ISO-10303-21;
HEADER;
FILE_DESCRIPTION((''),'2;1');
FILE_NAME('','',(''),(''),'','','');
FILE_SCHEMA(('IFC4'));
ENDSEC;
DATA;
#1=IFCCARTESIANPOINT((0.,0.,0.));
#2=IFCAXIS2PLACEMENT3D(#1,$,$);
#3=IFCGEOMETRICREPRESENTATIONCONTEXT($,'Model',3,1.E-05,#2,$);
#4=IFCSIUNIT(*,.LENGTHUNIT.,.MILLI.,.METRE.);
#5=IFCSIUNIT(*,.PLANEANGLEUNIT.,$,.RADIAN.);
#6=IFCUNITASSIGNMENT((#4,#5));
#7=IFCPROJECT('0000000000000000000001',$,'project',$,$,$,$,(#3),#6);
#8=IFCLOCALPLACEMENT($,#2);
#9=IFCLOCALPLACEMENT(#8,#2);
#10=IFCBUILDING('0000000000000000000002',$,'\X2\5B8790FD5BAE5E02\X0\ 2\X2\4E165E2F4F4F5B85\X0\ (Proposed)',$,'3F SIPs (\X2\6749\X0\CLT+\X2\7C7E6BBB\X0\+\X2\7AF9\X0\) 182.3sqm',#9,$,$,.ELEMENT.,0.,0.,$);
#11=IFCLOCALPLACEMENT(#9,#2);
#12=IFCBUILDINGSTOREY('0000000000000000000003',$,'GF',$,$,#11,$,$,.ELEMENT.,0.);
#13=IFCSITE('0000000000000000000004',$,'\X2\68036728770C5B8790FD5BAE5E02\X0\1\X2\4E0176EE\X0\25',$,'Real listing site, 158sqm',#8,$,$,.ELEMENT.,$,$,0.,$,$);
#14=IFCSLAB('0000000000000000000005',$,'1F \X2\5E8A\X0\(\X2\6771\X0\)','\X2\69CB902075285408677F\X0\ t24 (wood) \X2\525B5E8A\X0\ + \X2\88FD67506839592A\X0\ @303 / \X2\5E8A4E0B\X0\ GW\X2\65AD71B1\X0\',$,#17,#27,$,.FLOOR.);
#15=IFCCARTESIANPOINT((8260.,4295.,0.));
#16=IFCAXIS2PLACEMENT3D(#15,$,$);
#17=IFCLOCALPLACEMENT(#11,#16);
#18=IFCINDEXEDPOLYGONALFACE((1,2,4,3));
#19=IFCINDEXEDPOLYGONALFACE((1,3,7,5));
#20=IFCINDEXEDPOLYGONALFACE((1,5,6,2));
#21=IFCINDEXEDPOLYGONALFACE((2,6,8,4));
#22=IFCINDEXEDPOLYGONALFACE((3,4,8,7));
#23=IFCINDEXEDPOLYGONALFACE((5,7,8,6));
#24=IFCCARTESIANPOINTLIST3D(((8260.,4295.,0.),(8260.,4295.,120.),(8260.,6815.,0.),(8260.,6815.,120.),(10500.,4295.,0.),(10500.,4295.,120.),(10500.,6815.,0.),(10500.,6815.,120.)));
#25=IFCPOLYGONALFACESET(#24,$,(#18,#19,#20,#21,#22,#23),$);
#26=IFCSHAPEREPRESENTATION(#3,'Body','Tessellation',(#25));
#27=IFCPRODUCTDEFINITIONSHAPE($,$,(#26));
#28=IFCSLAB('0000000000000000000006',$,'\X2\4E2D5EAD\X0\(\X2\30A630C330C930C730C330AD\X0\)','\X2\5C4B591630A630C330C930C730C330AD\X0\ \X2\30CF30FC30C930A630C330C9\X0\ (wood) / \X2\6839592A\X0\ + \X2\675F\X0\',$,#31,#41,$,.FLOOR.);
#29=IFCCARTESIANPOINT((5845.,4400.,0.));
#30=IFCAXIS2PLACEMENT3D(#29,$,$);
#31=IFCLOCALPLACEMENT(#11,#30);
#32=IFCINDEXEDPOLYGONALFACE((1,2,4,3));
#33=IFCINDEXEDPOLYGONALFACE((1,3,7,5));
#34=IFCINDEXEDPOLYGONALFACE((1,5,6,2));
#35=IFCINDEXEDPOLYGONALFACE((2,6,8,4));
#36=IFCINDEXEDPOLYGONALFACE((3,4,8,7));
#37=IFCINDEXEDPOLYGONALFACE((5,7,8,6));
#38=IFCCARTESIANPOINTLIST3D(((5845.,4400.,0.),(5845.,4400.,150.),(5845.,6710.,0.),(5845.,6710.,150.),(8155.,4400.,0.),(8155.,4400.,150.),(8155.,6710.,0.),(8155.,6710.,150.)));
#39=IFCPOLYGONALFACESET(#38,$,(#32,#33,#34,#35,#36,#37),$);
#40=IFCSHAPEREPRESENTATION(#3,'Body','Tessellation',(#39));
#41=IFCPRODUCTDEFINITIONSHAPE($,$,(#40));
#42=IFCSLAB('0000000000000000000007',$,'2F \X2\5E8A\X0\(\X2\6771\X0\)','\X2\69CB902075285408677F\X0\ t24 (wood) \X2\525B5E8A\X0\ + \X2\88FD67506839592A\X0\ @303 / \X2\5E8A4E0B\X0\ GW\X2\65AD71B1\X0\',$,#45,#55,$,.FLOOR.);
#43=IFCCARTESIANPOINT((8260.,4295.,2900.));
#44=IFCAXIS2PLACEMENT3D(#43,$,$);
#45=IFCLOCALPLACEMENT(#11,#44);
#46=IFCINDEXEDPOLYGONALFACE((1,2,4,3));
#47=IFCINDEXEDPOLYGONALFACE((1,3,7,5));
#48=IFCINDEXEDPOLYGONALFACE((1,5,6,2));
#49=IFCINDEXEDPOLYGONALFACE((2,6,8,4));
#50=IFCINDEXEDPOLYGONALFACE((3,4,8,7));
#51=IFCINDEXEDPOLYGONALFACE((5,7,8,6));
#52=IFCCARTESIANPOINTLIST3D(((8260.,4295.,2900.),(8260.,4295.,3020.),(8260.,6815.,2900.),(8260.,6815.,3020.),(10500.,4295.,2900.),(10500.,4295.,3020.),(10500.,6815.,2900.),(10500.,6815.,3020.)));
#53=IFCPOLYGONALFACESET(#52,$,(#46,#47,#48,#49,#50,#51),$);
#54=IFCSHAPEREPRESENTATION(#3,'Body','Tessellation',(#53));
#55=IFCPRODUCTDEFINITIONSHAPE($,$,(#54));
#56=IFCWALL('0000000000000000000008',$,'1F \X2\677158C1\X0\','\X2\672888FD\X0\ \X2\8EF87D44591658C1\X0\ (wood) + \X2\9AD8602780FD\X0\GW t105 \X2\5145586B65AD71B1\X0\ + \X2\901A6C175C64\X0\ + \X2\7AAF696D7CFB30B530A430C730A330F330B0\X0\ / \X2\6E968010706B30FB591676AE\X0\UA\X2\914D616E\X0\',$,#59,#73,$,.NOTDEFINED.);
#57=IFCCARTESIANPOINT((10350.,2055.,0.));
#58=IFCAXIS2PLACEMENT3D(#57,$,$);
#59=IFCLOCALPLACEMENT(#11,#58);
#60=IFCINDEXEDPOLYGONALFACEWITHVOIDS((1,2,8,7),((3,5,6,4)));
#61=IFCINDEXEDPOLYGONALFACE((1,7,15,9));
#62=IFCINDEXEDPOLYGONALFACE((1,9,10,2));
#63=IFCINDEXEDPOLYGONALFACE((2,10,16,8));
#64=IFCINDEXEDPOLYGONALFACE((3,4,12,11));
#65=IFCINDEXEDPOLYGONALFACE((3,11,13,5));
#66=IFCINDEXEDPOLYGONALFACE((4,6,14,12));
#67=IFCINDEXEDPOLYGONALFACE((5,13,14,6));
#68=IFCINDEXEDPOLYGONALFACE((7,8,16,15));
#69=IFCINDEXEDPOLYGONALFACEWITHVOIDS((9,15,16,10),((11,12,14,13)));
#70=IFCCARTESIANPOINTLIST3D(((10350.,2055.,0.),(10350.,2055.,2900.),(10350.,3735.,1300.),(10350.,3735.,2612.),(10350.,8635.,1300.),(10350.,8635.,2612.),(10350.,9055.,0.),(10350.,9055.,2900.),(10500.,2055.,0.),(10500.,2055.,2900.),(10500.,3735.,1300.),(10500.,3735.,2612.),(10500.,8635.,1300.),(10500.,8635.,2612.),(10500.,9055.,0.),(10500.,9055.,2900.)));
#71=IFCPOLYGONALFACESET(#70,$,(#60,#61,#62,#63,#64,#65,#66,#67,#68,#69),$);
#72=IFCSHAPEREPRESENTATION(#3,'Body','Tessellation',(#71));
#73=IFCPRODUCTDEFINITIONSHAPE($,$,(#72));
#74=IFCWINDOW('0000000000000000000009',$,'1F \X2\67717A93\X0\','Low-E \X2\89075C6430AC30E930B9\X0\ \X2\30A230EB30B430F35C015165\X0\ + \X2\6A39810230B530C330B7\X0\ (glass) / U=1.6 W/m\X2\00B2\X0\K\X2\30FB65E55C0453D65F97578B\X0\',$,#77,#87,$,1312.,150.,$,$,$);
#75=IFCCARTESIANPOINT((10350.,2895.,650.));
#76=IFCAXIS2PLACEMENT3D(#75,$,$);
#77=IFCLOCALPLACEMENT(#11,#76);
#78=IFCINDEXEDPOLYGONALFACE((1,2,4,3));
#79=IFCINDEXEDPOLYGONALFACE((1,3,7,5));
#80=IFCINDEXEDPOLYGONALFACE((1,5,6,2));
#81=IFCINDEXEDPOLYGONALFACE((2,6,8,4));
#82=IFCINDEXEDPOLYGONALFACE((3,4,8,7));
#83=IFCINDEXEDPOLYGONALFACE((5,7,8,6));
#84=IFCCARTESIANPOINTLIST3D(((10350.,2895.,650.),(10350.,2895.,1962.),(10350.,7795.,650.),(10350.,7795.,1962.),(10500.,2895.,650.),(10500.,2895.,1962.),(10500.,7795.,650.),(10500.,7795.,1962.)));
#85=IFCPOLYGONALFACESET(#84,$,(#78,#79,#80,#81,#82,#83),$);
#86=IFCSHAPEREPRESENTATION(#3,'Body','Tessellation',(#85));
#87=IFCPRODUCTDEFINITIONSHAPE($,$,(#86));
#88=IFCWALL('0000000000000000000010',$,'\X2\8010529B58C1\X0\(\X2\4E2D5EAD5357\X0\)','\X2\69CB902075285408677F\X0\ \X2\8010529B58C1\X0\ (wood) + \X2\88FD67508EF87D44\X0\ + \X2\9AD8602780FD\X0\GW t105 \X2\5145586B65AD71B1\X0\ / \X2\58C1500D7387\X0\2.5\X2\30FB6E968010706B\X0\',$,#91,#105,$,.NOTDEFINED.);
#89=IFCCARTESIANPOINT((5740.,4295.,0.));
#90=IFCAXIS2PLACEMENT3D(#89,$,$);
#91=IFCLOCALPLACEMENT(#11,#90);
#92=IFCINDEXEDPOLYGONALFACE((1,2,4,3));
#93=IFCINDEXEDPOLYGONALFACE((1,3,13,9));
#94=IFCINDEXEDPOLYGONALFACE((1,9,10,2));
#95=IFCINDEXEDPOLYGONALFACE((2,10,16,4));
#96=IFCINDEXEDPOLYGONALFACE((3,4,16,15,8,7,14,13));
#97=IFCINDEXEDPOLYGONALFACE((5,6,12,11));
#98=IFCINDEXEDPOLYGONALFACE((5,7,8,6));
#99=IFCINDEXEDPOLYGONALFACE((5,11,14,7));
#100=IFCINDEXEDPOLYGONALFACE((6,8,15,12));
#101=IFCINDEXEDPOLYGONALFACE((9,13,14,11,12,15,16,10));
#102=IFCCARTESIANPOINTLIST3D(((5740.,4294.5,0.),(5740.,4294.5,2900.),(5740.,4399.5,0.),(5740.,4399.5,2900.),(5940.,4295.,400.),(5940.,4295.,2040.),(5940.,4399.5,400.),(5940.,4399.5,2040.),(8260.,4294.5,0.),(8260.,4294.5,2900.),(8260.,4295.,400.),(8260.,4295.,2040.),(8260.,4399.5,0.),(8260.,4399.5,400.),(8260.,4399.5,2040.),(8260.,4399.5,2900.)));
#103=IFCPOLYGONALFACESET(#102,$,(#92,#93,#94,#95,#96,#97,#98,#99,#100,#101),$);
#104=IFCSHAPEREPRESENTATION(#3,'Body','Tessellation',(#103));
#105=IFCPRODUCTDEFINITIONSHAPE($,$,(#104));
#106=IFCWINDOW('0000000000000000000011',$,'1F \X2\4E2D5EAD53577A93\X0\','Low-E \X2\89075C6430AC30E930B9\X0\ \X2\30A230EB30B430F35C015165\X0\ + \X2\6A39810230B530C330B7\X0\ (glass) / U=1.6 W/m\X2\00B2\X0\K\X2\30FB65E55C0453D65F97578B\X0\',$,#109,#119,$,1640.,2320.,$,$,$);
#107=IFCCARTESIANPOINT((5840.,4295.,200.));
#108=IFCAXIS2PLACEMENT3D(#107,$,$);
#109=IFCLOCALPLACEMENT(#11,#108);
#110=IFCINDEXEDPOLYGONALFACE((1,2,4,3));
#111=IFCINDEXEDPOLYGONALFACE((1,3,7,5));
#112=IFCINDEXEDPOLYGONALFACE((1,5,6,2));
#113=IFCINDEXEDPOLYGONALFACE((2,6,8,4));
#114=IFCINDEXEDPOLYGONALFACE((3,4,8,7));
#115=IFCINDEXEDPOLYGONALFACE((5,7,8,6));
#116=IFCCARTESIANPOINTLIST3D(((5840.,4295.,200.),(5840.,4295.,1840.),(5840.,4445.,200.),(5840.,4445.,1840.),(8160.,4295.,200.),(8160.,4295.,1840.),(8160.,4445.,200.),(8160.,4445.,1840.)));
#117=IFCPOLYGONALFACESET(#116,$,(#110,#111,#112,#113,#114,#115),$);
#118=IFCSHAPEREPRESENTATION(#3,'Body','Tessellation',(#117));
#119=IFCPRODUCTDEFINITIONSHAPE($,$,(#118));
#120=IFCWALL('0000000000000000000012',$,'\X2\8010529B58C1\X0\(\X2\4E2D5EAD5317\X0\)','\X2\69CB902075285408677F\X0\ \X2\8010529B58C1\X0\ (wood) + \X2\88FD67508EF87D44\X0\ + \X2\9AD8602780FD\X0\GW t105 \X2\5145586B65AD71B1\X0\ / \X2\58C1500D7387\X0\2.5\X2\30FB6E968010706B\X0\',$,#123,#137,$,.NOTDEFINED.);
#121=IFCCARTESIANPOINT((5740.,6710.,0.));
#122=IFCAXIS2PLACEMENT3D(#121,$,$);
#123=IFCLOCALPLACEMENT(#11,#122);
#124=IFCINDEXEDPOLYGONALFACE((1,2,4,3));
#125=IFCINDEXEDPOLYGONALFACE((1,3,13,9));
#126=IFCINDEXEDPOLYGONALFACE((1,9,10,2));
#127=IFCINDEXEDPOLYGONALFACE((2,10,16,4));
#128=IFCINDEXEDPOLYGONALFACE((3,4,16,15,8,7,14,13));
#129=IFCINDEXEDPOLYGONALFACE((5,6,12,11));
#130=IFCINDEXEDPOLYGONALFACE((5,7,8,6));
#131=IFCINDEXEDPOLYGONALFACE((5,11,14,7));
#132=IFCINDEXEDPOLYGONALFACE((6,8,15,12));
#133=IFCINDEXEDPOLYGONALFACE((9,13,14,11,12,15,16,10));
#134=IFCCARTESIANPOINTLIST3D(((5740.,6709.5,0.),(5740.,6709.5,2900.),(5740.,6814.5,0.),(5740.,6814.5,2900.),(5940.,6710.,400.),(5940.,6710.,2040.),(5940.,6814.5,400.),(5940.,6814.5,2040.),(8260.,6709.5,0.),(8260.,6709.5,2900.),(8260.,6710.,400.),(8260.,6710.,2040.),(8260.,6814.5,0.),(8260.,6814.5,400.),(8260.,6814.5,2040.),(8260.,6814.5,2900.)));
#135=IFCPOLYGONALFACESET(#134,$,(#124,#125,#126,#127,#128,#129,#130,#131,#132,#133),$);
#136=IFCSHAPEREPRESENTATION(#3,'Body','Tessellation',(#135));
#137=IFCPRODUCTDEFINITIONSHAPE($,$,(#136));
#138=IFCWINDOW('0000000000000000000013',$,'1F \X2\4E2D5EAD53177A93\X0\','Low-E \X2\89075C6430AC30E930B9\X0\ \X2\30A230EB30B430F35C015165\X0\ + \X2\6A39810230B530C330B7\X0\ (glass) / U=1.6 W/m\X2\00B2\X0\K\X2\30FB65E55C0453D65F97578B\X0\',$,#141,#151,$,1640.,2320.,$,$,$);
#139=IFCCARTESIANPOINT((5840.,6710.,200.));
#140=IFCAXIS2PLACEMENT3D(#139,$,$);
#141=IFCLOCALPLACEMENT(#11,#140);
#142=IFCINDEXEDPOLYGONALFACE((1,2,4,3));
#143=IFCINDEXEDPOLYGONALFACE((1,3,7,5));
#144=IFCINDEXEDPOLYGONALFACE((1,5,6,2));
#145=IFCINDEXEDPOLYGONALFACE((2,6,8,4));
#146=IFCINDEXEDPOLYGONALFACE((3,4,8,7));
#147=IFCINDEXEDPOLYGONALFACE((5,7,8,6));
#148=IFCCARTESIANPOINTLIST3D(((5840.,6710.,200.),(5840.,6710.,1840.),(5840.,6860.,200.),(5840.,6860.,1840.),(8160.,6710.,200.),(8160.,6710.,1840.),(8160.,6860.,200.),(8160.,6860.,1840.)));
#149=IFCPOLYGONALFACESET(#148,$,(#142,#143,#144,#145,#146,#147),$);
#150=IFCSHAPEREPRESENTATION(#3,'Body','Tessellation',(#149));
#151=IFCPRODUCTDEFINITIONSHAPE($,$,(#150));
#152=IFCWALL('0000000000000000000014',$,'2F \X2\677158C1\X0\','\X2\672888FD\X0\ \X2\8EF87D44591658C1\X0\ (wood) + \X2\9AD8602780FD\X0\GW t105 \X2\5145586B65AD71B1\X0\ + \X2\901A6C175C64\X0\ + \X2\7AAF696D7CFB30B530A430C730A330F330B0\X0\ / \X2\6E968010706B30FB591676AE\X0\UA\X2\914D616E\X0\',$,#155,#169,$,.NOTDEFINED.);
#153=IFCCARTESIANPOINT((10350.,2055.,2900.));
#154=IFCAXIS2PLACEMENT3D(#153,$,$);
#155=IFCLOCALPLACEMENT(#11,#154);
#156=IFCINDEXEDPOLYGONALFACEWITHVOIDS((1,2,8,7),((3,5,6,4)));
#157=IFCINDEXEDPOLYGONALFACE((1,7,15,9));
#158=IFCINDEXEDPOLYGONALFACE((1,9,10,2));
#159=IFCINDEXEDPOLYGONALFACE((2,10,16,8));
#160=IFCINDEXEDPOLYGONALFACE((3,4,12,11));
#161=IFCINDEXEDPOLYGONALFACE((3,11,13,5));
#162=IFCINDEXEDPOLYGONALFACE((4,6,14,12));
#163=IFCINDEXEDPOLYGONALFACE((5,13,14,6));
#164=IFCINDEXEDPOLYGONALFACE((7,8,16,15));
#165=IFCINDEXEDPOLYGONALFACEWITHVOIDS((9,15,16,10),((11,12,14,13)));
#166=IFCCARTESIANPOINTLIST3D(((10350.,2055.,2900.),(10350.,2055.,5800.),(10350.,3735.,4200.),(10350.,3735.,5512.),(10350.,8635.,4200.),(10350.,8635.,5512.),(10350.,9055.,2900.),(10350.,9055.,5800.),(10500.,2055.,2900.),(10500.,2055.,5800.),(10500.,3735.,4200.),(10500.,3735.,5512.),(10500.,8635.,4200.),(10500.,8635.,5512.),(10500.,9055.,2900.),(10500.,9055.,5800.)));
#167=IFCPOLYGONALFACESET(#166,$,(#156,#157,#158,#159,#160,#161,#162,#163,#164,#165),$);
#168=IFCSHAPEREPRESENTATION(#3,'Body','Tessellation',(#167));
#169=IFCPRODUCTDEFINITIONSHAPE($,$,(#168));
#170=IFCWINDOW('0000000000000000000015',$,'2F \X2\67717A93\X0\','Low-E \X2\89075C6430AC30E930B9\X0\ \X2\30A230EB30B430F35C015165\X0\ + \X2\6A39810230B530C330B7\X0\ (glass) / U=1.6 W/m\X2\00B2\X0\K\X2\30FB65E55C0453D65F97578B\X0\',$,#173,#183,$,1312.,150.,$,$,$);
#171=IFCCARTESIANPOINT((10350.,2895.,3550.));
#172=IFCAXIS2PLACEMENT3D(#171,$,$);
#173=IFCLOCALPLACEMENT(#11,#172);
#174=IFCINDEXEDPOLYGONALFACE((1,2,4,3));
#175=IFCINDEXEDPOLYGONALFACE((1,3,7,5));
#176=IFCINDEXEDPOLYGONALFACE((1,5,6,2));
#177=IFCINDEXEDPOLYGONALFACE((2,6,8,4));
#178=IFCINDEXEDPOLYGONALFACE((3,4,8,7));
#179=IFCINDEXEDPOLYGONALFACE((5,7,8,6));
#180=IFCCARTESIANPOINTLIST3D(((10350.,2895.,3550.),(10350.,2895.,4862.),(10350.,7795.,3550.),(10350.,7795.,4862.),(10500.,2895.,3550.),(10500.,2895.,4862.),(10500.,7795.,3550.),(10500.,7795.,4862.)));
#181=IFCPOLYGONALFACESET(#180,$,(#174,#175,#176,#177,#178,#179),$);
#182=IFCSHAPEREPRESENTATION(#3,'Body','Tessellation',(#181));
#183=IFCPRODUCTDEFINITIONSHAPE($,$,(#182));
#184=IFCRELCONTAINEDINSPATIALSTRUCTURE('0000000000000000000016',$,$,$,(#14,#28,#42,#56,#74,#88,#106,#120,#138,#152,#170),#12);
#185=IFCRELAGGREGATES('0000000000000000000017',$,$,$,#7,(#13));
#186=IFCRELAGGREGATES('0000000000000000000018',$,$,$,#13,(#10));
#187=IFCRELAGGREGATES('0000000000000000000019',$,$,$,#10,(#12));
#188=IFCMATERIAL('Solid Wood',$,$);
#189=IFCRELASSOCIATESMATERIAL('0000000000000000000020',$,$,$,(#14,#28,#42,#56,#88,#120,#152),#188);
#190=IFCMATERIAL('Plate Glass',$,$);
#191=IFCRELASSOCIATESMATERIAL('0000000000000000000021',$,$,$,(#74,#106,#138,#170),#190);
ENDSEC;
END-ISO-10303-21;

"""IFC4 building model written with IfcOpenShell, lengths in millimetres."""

from ifc_helpers import new_model, si_unit, frame, frame_2d, origin, place, context, project, spatial, rectangle, extrude, material, element, fill, save


model = new_model("IFC4")

# Units and contexts
model_context = context("Model", 3, precision=1e-05, world=origin())
ifc_project = project(units=[si_unit("LENGTHUNIT", "METRE", prefix="MILLI"), si_unit("PLANEANGLEUNIT", "RADIAN")], contexts=[model_context])

# Site, building, storey
site_placement = place(None, origin())
site = spatial("IfcSite", under=ifc_project, at=site_placement, Name="栃木県宇都宮市1丁目25", ObjectType="Real listing site, 158sqm", CompositionType="ELEMENT", RefElevation=0.0)
building_placement = place(site_placement, origin())
building = spatial("IfcBuilding", under=site, at=building_placement, Name="宇都宮市 2世帯住宅 (Proposed)", ObjectType="3F SIPs (杉CLT+籾殻+竹) 182.3sqm", CompositionType="ELEMENT", ElevationOfRefHeight=0.0, ElevationOfTerrain=0.0)
storey_placement = place(building_placement, origin())
storey = spatial("IfcBuildingStorey", under=building, at=storey_placement, Name="GF", CompositionType="ELEMENT", Elevation=0.0)

# Slabs
ifc_material_1 = material(Name="Solid Wood")
slab_1_placement = place(storey_placement, frame((8260.0, 4295.0, 0.0)))
element("IfcSlab", 1, at=slab_1_placement, inside=storey, material=ifc_material_1, Name="1F 床(東)", Description="構造用合板 t24 (wood) 剛床 + 製材根太 @303 / 床下 GW断熱", PredefinedType="FLOOR", context=model_context, shape_type="SweptSolid", body=[
    extrude(rectangle(XDim=2240.0, YDim=2520.0, at=frame_2d((1120.0, 1260.0))), frame((8260.0, 4295.0, 0.0)), (0.0, 0.0, 1.0), 120.0),
])
slab_2_placement = place(storey_placement, frame((5845.0, 4400.0, 0.0)))
element("IfcSlab", 2, at=slab_2_placement, inside=storey, material=ifc_material_1, Name="中庭(ウッドデッキ)", Description="屋外ウッドデッキ ハードウッド (wood) / 根太 + 束", PredefinedType="FLOOR", context=model_context, shape_type="SweptSolid", body=[
    extrude(rectangle(XDim=2310.0, YDim=2310.0, at=frame_2d((1155.0, 1155.0))), frame((5845.0, 4400.0, 0.0)), (0.0, 0.0, 1.0), 150.0),
])
slab_3_placement = place(storey_placement, frame((8260.0, 4295.0, 2900.0)))
element("IfcSlab", 3, at=slab_3_placement, inside=storey, material=ifc_material_1, Name="2F 床(東)", Description="構造用合板 t24 (wood) 剛床 + 製材根太 @303 / 床下 GW断熱", PredefinedType="FLOOR", context=model_context, shape_type="SweptSolid", body=[
    extrude(rectangle(XDim=2240.0, YDim=2520.0, at=frame_2d((1120.0, 1260.0))), frame((8260.0, 4295.0, 2900.0)), (0.0, 0.0, 1.0), 120.0),
])

# Walls, openings, windows
wall_1_placement = place(storey_placement, frame((10350.0, 2055.0, 0.0)))
wall_1 = element("IfcWall", 4, at=wall_1_placement, inside=storey, material=ifc_material_1, Name="1F 東壁", Description="木製 軸組外壁 (wood) + 高性能GW t105 充填断熱 + 通気層 + 窯業系サイディング / 準耐火・外皮UA配慮", PredefinedType="NOTDEFINED", context=model_context, shape_type="SweptSolid", body=[
    extrude(rectangle(XDim=150.0, YDim=7000.0, at=frame_2d((75.0, 3500.0))), frame((10350.0, 2055.0, 0.0)), (0.0, 0.0, 1.0), 2900.0),
])
opening_1_placement = place(storey_placement, frame((10350.0, 2895.0, 650.0)))
opening_1 = element("IfcOpeningElement", 5, at=opening_1_placement, cuts=wall_1, PredefinedType="NOTDEFINED", context=model_context, shape_type="SweptSolid", body=[
    extrude(rectangle(XDim=150.0, YDim=4900.0, at=frame_2d((75.0, 2450.0))), frame((10350.0, 2895.0, 650.0)), (0.0, 0.0, 1.0), 1312.0),
])
ifc_material_2 = material(Name="Plate Glass")
window_1_placement = place(storey_placement, frame((10350.0, 2895.0, 650.0)))
window_1 = element("IfcWindow", 6, at=window_1_placement, inside=storey, material=ifc_material_2, Name="1F 東窓", Description="Low-E 複層ガラス アルゴン封入 + 樹脂サッシ (glass) / U=1.6 W/m²K・日射取得型", OverallHeight=1312.0, OverallWidth=150.0, context=model_context, shape_type="SweptSolid", body=[
    extrude(rectangle(XDim=150.0, YDim=4900.0, at=frame_2d((75.0, 2450.0))), frame((10350.0, 2895.0, 650.0)), (0.0, 0.0, 1.0), 1312.0),
])
fill(opening_1, window_1)
wall_2_placement = place(storey_placement, frame((5740.0, 4295.0, 0.0)))
wall_2 = element("IfcWall", 7, at=wall_2_placement, inside=storey, material=ifc_material_1, Name="耐力壁(中庭南)", Description="構造用合板 耐力壁 (wood) + 製材軸組 + 高性能GW t105 充填断熱 / 壁倍率2.5・準耐火", PredefinedType="NOTDEFINED", context=model_context, shape_type="SweptSolid", body=[
    extrude(rectangle(XDim=2520.0, YDim=105.0, at=frame_2d((1260.0, 52.0))), frame((5740.0, 4295.0, 0.0)), (0.0, 0.0, 1.0), 2900.0),
])
opening_2_placement = place(storey_placement, frame((5840.0, 4295.0, 200.0)))
opening_2 = element("IfcOpeningElement", 8, at=opening_2_placement, cuts=wall_2, PredefinedType="NOTDEFINED", context=model_context, shape_type="SweptSolid", body=[
    extrude(rectangle(XDim=2320.0, YDim=150.0, at=frame_2d((1160.0, 75.0))), frame((5840.0, 4295.0, 200.0)), (0.0, 0.0, 1.0), 1640.0),
])
window_2_placement = place(storey_placement, frame((5840.0, 4295.0, 200.0)))
window_2 = element("IfcWindow", 9, at=window_2_placement, inside=storey, material=ifc_material_2, Name="1F 中庭南窓", Description="Low-E 複層ガラス アルゴン封入 + 樹脂サッシ (glass) / U=1.6 W/m²K・日射取得型", OverallHeight=1640.0, OverallWidth=2320.0, context=model_context, shape_type="SweptSolid", body=[
    extrude(rectangle(XDim=2320.0, YDim=150.0, at=frame_2d((1160.0, 75.0))), frame((5840.0, 4295.0, 200.0)), (0.0, 0.0, 1.0), 1640.0),
])
fill(opening_2, window_2)
wall_3_placement = place(storey_placement, frame((5740.0, 6710.0, 0.0)))
wall_3 = element("IfcWall", 10, at=wall_3_placement, inside=storey, material=ifc_material_1, Name="耐力壁(中庭北)", Description="構造用合板 耐力壁 (wood) + 製材軸組 + 高性能GW t105 充填断熱 / 壁倍率2.5・準耐火", PredefinedType="NOTDEFINED", context=model_context, shape_type="SweptSolid", body=[
    extrude(rectangle(XDim=2520.0, YDim=105.0, at=frame_2d((1260.0, 52.0))), frame((5740.0, 6710.0, 0.0)), (0.0, 0.0, 1.0), 2900.0),
])
opening_3_placement = place(storey_placement, frame((5840.0, 6710.0, 200.0)))
opening_3 = element("IfcOpeningElement", 11, at=opening_3_placement, cuts=wall_3, PredefinedType="NOTDEFINED", context=model_context, shape_type="SweptSolid", body=[
    extrude(rectangle(XDim=2320.0, YDim=150.0, at=frame_2d((1160.0, 75.0))), frame((5840.0, 6710.0, 200.0)), (0.0, 0.0, 1.0), 1640.0),
])
window_3_placement = place(storey_placement, frame((5840.0, 6710.0, 200.0)))
window_3 = element("IfcWindow", 12, at=window_3_placement, inside=storey, material=ifc_material_2, Name="1F 中庭北窓", Description="Low-E 複層ガラス アルゴン封入 + 樹脂サッシ (glass) / U=1.6 W/m²K・日射取得型", OverallHeight=1640.0, OverallWidth=2320.0, context=model_context, shape_type="SweptSolid", body=[
    extrude(rectangle(XDim=2320.0, YDim=150.0, at=frame_2d((1160.0, 75.0))), frame((5840.0, 6710.0, 200.0)), (0.0, 0.0, 1.0), 1640.0),
])
fill(opening_3, window_3)

# Wall, opening, window
wall_4_placement = place(storey_placement, frame((10350.0, 2055.0, 2900.0)))
wall_4 = element("IfcWall", 13, at=wall_4_placement, inside=storey, material=ifc_material_1, Name="2F 東壁", Description="木製 軸組外壁 (wood) + 高性能GW t105 充填断熱 + 通気層 + 窯業系サイディング / 準耐火・外皮UA配慮", PredefinedType="NOTDEFINED", context=model_context, shape_type="SweptSolid", body=[
    extrude(rectangle(XDim=150.0, YDim=7000.0, at=frame_2d((75.0, 3500.0))), frame((10350.0, 2055.0, 2900.0)), (0.0, 0.0, 1.0), 2900.0),
])
opening_4_placement = place(storey_placement, frame((10350.0, 2895.0, 3550.0)))
opening_4 = element("IfcOpeningElement", 14, at=opening_4_placement, cuts=wall_4, PredefinedType="NOTDEFINED", context=model_context, shape_type="SweptSolid", body=[
    extrude(rectangle(XDim=150.0, YDim=4900.0, at=frame_2d((75.0, 2450.0))), frame((10350.0, 2895.0, 3550.0)), (0.0, 0.0, 1.0), 1312.0),
])
window_4_placement = place(storey_placement, frame((10350.0, 2895.0, 3550.0)))
window_4 = element("IfcWindow", 15, at=window_4_placement, inside=storey, material=ifc_material_2, Name="2F 東窓", Description="Low-E 複層ガラス アルゴン封入 + 樹脂サッシ (glass) / U=1.6 W/m²K・日射取得型", OverallHeight=1312.0, OverallWidth=150.0, context=model_context, shape_type="SweptSolid", body=[
    extrude(rectangle(XDim=150.0, YDim=4900.0, at=frame_2d((75.0, 2450.0))), frame((10350.0, 2895.0, 3550.0)), (0.0, 0.0, 1.0), 1312.0),
])
fill(opening_4, window_4)

save(model, "model.ifc")
